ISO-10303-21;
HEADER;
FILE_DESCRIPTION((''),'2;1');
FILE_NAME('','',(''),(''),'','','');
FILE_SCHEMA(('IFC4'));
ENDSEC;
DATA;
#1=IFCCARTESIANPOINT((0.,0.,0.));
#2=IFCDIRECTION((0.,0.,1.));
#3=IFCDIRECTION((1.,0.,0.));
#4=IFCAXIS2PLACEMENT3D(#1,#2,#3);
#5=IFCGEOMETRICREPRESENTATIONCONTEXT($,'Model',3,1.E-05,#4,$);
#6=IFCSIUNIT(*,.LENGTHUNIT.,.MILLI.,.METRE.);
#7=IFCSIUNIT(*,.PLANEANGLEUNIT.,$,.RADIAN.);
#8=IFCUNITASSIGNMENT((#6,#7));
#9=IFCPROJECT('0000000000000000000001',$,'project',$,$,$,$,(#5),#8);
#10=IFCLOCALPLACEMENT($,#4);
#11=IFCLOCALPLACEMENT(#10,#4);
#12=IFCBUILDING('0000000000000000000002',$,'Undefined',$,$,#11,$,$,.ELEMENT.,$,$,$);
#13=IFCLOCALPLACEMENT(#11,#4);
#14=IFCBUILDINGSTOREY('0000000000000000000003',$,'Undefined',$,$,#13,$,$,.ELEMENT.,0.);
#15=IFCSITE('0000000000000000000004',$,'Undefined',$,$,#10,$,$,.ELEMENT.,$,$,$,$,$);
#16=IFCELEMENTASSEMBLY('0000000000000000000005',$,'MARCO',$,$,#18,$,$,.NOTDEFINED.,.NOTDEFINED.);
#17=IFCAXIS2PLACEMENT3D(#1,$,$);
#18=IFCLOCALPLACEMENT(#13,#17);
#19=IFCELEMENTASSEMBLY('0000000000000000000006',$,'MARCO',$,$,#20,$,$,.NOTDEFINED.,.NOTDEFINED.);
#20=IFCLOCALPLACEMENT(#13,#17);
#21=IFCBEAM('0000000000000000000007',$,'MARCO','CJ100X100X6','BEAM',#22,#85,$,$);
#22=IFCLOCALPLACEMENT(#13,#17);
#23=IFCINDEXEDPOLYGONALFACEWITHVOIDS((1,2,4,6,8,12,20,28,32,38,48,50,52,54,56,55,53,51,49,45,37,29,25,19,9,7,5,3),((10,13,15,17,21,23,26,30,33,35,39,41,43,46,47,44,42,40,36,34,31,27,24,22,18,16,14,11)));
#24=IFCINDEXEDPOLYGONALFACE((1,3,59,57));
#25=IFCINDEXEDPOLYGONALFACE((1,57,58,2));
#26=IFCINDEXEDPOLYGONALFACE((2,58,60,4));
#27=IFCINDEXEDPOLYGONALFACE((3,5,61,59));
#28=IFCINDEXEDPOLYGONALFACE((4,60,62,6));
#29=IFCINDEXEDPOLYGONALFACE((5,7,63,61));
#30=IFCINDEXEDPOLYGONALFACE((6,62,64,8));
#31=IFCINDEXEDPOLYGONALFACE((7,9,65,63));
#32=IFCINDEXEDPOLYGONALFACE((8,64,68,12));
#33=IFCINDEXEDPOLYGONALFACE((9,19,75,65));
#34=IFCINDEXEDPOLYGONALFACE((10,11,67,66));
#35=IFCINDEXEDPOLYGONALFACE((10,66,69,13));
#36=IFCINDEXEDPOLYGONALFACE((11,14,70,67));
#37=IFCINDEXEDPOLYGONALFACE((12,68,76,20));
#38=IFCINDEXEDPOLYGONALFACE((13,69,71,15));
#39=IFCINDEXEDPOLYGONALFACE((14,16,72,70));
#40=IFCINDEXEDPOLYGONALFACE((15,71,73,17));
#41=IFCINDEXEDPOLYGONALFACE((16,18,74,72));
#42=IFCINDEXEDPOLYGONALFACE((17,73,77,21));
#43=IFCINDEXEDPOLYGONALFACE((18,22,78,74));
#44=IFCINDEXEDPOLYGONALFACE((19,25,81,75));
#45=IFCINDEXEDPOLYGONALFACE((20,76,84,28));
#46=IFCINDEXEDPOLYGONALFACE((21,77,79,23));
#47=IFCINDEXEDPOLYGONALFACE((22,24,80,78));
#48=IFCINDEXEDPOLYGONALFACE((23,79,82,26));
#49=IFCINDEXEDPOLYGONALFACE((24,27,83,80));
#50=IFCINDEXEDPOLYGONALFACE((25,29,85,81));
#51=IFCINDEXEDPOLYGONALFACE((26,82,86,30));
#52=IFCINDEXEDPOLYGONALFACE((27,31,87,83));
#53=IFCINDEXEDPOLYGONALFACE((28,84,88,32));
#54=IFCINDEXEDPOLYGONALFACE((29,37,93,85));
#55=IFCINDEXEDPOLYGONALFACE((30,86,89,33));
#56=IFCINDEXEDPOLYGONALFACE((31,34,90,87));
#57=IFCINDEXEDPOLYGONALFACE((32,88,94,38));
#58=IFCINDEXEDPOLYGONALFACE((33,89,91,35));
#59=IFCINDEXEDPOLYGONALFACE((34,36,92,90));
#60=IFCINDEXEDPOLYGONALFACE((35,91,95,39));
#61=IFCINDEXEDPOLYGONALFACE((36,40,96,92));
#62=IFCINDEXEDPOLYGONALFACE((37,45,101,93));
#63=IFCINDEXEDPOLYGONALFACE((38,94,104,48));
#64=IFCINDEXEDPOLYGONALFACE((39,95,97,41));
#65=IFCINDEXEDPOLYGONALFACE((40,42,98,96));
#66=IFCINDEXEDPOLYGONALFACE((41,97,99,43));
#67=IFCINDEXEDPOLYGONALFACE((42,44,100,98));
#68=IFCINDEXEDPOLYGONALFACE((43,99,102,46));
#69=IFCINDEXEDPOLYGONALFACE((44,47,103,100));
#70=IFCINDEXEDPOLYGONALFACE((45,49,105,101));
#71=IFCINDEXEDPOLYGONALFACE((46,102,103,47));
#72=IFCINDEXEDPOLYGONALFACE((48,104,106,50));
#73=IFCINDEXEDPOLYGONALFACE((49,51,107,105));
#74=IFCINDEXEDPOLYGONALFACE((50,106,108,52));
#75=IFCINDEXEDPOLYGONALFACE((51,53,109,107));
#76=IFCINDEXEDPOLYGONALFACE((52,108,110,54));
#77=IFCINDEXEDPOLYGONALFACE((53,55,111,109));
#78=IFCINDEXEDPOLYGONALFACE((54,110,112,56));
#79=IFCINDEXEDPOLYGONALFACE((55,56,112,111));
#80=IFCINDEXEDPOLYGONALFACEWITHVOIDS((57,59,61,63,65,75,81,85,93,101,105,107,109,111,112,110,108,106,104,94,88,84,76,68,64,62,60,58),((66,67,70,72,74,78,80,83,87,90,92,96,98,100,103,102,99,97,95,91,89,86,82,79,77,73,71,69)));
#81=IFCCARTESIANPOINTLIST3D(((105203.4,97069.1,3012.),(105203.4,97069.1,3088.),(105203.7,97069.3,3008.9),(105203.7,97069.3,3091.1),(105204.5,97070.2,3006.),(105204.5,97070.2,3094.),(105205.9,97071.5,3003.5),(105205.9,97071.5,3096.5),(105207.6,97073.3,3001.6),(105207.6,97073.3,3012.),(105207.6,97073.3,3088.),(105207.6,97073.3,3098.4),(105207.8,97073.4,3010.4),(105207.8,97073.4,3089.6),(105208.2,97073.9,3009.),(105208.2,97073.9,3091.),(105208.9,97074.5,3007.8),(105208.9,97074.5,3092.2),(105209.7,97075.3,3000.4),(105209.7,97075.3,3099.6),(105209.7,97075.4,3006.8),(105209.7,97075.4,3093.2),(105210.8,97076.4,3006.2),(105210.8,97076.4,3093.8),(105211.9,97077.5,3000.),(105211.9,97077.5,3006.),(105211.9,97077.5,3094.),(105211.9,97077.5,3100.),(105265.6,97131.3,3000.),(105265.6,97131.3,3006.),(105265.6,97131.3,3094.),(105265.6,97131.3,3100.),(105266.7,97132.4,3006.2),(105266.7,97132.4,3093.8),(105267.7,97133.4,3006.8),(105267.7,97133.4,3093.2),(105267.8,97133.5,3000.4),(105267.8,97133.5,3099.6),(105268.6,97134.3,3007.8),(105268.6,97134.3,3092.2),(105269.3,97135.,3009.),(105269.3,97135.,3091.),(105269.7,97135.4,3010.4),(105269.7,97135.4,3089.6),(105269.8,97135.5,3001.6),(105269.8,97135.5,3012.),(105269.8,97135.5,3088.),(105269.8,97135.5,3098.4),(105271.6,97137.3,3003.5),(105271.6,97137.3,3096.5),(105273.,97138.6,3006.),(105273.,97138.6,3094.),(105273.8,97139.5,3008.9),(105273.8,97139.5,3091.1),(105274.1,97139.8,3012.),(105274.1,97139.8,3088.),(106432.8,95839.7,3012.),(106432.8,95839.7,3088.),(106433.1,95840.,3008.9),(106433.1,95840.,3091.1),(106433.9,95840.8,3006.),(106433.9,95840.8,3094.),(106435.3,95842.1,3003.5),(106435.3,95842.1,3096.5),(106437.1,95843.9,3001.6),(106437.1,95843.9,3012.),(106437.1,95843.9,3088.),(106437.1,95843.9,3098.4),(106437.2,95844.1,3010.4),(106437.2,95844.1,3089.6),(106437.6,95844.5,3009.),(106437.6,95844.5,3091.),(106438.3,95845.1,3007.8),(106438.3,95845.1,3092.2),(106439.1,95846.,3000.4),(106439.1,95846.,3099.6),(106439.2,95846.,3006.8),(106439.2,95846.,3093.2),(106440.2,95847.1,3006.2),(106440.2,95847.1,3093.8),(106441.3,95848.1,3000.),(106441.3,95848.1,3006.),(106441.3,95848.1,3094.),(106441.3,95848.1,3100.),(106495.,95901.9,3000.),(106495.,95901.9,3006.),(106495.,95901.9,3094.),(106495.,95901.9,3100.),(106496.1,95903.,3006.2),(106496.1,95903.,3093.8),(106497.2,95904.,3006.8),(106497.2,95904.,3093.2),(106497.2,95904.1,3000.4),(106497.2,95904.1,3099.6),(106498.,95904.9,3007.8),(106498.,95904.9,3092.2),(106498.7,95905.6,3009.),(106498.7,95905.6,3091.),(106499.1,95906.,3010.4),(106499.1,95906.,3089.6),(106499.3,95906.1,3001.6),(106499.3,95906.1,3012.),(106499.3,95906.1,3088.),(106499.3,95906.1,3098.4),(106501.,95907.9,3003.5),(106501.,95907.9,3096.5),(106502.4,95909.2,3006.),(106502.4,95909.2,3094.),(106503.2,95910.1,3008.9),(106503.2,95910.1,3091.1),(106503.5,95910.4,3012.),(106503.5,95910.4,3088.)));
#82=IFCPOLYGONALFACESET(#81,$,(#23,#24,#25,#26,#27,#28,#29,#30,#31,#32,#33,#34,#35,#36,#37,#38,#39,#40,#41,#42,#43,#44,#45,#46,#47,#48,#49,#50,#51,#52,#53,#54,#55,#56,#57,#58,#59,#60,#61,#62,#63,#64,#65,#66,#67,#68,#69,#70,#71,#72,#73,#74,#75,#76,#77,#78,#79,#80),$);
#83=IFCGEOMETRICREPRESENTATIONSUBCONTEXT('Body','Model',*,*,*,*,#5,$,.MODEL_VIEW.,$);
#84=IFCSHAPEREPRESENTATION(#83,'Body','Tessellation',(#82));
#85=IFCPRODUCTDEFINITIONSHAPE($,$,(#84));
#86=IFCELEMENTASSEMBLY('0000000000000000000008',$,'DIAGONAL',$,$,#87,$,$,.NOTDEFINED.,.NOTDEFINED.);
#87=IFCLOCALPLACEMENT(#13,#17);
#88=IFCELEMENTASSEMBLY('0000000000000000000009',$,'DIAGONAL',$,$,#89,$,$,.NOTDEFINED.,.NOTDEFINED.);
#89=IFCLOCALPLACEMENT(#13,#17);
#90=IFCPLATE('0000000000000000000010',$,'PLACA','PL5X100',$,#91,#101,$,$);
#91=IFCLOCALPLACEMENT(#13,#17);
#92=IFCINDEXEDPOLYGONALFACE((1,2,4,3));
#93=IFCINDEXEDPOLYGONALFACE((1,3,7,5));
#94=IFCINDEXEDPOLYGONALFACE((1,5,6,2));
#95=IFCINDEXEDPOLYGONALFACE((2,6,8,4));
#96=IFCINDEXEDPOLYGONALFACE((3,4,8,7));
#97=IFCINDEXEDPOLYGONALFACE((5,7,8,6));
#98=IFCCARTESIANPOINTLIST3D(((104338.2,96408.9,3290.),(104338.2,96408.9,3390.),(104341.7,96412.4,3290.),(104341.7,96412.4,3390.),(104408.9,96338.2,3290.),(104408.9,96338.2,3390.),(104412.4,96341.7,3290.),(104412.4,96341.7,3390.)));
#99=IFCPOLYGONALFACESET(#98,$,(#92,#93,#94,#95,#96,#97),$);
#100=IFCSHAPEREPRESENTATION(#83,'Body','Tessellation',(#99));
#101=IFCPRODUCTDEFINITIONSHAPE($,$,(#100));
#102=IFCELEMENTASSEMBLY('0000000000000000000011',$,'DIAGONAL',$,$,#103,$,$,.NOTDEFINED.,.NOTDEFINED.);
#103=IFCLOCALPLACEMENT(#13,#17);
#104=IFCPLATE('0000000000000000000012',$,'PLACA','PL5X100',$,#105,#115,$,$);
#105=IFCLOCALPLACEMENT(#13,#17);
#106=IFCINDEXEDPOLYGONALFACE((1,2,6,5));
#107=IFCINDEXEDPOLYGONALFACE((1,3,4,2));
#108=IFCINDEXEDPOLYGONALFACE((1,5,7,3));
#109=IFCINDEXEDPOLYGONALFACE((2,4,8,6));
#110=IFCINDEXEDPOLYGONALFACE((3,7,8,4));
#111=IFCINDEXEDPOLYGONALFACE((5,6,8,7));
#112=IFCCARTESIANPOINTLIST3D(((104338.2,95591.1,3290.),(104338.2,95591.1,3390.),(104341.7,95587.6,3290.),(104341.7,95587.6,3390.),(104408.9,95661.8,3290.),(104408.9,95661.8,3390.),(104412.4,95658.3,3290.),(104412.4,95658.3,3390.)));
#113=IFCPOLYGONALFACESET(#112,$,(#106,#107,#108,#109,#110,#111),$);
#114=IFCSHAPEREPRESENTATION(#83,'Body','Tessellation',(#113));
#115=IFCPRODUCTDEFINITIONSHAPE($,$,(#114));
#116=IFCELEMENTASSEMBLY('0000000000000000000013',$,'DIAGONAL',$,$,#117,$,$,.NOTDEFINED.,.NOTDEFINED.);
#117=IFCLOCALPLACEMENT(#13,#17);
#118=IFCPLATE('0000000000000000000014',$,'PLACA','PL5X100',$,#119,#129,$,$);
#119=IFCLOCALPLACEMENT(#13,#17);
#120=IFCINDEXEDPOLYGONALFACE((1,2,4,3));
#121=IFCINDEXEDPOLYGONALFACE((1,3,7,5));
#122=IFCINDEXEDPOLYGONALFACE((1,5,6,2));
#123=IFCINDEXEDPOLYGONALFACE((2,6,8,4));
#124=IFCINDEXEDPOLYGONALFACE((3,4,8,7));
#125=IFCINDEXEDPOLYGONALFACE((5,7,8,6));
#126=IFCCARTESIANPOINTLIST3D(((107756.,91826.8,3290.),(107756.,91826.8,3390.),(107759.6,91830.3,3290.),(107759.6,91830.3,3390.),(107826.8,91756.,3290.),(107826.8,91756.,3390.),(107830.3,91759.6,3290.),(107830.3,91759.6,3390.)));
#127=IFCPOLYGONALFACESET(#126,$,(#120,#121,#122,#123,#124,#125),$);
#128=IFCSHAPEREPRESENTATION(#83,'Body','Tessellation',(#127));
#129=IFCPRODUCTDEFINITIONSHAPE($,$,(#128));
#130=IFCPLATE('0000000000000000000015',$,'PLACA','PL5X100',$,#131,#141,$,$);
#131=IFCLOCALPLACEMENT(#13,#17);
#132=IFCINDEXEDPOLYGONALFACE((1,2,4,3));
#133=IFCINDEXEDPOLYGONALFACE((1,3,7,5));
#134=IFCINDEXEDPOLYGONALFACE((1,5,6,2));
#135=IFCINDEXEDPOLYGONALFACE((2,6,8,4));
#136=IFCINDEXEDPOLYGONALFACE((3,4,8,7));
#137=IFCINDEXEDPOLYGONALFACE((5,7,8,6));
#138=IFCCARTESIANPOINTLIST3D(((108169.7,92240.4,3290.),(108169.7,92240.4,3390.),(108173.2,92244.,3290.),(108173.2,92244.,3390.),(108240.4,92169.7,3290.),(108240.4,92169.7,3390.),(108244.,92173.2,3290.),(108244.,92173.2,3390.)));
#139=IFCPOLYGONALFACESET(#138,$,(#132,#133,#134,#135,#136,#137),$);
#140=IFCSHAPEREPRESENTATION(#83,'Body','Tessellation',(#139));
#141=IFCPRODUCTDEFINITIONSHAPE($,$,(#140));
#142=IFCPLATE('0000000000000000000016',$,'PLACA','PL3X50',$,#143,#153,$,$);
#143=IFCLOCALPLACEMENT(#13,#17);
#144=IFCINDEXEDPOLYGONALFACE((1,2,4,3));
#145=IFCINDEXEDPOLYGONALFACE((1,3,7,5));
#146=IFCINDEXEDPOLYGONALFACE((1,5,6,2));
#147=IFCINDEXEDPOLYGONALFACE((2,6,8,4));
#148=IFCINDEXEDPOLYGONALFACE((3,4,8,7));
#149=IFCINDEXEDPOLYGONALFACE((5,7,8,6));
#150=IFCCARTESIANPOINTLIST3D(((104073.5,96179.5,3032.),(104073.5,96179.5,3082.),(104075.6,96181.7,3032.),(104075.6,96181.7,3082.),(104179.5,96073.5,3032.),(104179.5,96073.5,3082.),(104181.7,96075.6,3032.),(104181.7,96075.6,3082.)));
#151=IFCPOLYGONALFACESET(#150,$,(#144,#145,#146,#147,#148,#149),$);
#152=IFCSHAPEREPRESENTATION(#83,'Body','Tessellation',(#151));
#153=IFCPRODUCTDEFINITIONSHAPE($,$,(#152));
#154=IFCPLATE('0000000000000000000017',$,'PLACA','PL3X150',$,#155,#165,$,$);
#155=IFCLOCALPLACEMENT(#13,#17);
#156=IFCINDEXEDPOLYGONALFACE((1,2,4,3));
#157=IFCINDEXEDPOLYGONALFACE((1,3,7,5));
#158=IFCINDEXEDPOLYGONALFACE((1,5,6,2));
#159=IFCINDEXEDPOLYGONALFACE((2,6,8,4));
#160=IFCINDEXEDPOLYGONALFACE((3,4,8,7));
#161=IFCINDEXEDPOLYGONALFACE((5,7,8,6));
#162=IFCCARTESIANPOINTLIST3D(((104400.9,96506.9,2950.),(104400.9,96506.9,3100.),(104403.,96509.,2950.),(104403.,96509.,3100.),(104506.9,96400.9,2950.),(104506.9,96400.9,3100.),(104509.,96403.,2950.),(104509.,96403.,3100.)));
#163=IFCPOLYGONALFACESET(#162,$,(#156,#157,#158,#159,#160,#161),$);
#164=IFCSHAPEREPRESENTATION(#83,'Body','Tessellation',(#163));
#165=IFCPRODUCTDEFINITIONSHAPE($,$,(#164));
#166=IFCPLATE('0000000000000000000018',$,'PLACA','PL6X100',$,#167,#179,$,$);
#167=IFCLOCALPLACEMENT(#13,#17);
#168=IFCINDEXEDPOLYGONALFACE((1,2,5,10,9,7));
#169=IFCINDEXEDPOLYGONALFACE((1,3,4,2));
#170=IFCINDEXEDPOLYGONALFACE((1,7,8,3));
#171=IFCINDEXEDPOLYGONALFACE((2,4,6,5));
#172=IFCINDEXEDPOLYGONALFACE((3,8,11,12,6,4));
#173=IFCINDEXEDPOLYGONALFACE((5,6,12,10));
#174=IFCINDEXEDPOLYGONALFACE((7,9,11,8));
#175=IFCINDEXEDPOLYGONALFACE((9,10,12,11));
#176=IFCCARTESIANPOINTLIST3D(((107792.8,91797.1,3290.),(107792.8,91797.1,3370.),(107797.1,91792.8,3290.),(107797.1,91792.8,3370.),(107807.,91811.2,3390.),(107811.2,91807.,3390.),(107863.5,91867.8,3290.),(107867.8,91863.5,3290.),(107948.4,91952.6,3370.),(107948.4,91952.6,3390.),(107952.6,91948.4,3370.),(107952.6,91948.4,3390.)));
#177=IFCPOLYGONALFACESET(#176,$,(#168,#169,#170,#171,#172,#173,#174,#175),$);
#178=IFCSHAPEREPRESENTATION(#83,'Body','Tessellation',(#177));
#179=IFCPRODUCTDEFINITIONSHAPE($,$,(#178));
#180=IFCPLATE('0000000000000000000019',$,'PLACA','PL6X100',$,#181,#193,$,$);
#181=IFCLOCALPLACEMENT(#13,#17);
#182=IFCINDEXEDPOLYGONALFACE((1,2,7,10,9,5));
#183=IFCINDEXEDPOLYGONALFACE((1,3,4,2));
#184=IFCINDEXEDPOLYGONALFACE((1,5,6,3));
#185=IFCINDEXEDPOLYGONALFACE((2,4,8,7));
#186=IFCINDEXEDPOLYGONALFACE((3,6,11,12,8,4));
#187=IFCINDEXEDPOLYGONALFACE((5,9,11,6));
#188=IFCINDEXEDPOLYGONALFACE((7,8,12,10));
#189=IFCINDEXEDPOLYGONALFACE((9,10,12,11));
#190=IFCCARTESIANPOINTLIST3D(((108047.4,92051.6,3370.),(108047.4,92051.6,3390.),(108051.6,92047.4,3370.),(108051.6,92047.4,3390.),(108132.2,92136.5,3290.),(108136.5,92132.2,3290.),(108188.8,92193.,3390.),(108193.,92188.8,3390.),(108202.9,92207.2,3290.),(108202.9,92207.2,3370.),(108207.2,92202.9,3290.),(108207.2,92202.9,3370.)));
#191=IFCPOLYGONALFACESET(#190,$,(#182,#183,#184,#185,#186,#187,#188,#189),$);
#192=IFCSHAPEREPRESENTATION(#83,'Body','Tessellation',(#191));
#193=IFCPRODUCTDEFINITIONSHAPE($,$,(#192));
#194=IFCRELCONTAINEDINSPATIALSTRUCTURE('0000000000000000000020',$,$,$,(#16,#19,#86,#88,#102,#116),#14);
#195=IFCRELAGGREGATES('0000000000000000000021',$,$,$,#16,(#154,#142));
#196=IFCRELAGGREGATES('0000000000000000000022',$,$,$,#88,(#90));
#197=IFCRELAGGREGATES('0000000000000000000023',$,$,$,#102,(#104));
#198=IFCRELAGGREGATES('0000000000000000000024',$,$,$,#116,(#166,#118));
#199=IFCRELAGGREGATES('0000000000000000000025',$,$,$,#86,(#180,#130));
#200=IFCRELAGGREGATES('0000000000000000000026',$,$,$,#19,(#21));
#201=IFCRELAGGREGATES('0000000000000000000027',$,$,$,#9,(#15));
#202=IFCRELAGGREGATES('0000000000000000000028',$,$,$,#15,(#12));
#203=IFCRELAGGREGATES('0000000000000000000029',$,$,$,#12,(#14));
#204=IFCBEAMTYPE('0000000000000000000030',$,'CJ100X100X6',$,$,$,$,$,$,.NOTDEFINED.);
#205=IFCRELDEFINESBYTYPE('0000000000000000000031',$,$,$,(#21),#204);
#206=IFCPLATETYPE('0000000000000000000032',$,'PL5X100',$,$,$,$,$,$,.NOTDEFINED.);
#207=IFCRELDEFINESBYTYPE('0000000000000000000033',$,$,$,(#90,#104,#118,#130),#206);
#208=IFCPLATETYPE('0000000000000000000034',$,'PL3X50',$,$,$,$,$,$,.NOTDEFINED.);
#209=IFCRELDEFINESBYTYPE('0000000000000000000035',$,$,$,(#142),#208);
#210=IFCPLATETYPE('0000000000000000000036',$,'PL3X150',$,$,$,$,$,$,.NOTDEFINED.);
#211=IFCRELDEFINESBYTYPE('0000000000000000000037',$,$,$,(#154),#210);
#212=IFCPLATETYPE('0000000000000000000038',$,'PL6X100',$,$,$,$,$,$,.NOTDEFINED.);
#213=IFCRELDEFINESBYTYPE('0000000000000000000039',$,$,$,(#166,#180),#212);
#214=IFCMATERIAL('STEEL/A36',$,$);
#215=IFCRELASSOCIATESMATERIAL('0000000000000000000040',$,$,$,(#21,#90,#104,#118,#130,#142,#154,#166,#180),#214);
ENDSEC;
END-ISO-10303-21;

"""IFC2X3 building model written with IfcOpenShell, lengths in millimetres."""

from ifc_helpers import new_model, si_unit, frame, origin_with_axes, origin_2d_with_axis, place, context, subcontext, project, spatial, polyline, hollow_rectangle, outline, extrude, material, type_object, element, aggregate, save


model = new_model("IFC2X3")

# Units and contexts
model_context = context("Model", 3, precision=1e-05, world=origin_with_axes())
body_context = subcontext(model_context, "Body", "Model", "MODEL_VIEW")
ifc_project = project(units=[si_unit("LENGTHUNIT", "METRE", prefix="MILLI"), si_unit("PLANEANGLEUNIT", "RADIAN")], contexts=[model_context])

# Site, building, storey
site_placement = place(None, origin_with_axes())
site = spatial("IfcSite", under=ifc_project, at=site_placement, Name="Undefined", CompositionType="ELEMENT")
building_placement = place(site_placement, origin_with_axes())
building = spatial("IfcBuilding", under=site, at=building_placement, Name="Undefined", CompositionType="ELEMENT")
storey_placement = place(building_placement, origin_with_axes())
storey = spatial("IfcBuildingStorey", under=building, at=storey_placement, Name="Undefined", CompositionType="ELEMENT", Elevation=0.0)

# Shared definitions
ifc_material_1 = material(Name="STEEL/A36")

# Element assembly
assembly_1_placement = place(storey_placement, origin_with_axes())
assembly_1 = element("IfcElementAssembly", 1, at=assembly_1_placement, inside=storey, Name="MARCO", AssemblyPlace="NOTDEFINED", PredefinedType="NOTDEFINED")

# Element assemblies, beam
assembly_2_placement = place(storey_placement, origin_with_axes())
assembly_2 = element("IfcElementAssembly", 2, at=assembly_2_placement, inside=storey, Name="MARCO", AssemblyPlace="NOTDEFINED", PredefinedType="NOTDEFINED")
beam_type_1 = type_object("IfcBeamType", Name="CJ100X100X6", PredefinedType="NOTDEFINED")
beam_1_placement = place(assembly_2_placement, frame((105238.7, 97104.4, 3050.0), z_axis=(0.0, 0.0, -1.0), x_axis=(0.70712, -0.707094, 0.0)))
beam_1 = element("IfcBeam", 3, at=beam_1_placement, type_object=beam_type_1, material=ifc_material_1, Name="MARCO", Description="CJ100X100X6", ObjectType="BEAM", context=body_context, shape_type="SweptSolid", body=[
    extrude(hollow_rectangle(XDim=100.0, YDim=100.0, WallThickness=6.0, InnerFilletRadius=6.0, OuterFilletRadius=12.0, at=origin_2d_with_axis()), frame((1738.6, 0.0, 0.0), z_axis=(-1.0, 0.0, 0.0), x_axis=(0.0, -1.0, 0.0)), (0.0, 0.0, 1.0), 1738.7),
])
assembly_3_placement = place(storey_placement, origin_with_axes())
assembly_3 = element("IfcElementAssembly", 4, at=assembly_3_placement, inside=storey, Name="DIAGONAL", AssemblyPlace="NOTDEFINED", PredefinedType="NOTDEFINED")

# Element assemblies, plates
assembly_4_placement = place(storey_placement, origin_with_axes())
assembly_4 = element("IfcElementAssembly", 5, at=assembly_4_placement, inside=storey, Name="DIAGONAL", AssemblyPlace="NOTDEFINED", PredefinedType="NOTDEFINED")
plate_type_1 = type_object("IfcPlateType", Name="PL5X100", PredefinedType="NOTDEFINED")
plate_1_placement = place(assembly_4_placement, frame((104410.6, 96339.9, 3390.0), z_axis=(0.707107, 0.707107, 0.0), x_axis=(0.0, 0.0, -1.0)))
plate_1 = element("IfcPlate", 6, at=plate_1_placement, type_object=plate_type_1, material=ifc_material_1, Name="PLACA", Description="PL5X100", context=body_context, shape_type="SweptSolid", body=[
    extrude(outline(polyline([(0.0, 0.0), (100.0, 0.0), (100.0, 100.0), (0.0, 100.0), (0.0, 0.0)])), frame((0.0, 0.0, -2.5), z_axis=(0.0, 0.0, 1.0), x_axis=(1.0, 0.0, 0.0)), (0.0, 0.0, 1.0), 5.0),
])
assembly_5_placement = place(storey_placement, origin_with_axes())
assembly_5 = element("IfcElementAssembly", 7, at=assembly_5_placement, inside=storey, Name="DIAGONAL", AssemblyPlace="NOTDEFINED", PredefinedType="NOTDEFINED")
plate_2_placement = place(assembly_5_placement, frame((104339.9, 95589.4, 3390.0), z_axis=(0.707107, -0.707107, 0.0), x_axis=(0.0, 0.0, -1.0)))
plate_2 = element("IfcPlate", 8, at=plate_2_placement, type_object=plate_type_1, material=ifc_material_1, Name="PLACA", Description="PL5X100", context=body_context, shape_type="SweptSolid", body=[
    extrude(outline(polyline([(0.0, 0.0), (100.0, 0.0), (100.0, 100.0), (0.0, 100.0), (0.0, 0.0)])), frame((0.0, 0.0, -2.5), z_axis=(0.0, 0.0, 1.0), x_axis=(1.0, 0.0, 0.0)), (0.0, 0.0, 1.0), 5.0),
])
assembly_6_placement = place(storey_placement, origin_with_axes())
assembly_6 = element("IfcElementAssembly", 9, at=assembly_6_placement, inside=storey, Name="DIAGONAL", AssemblyPlace="NOTDEFINED", PredefinedType="NOTDEFINED")
plate_3_placement = place(assembly_6_placement, frame((107793.2, 91793.2, 3390.0), z_axis=(-0.707107, -0.707107, 0.0), x_axis=(0.0, 0.0, -1.0)))
plate_3 = element("IfcPlate", 10, at=plate_3_placement, type_object=plate_type_1, material=ifc_material_1, Name="PLACA", Description="PL5X100", context=body_context, shape_type="SweptSolid", body=[
    extrude(outline(polyline([(0.0, -50.0), (0.0, 50.0), (100.0, 50.0), (100.0, -50.0), (0.0, -50.0)])), frame((0.0, 0.0, -2.5), z_axis=(0.0, 0.0, 1.0), x_axis=(1.0, 0.0, 0.0)), (0.0, 0.0, 1.0), 5.0),
])

# Plates
plate_4_placement = place(assembly_3_placement, frame((108206.8, 92206.8, 3390.0), z_axis=(0.707107, 0.707107, 0.0), x_axis=(0.0, 0.0, -1.0)))
plate_4 = element("IfcPlate", 11, at=plate_4_placement, type_object=plate_type_1, material=ifc_material_1, Name="PLACA", Description="PL5X100", context=body_context, shape_type="SweptSolid", body=[
    extrude(outline(polyline([(0.0, -50.0), (0.0, 50.0), (100.0, 50.0), (100.0, -50.0), (0.0, -50.0)])), frame((0.0, 0.0, -2.5), z_axis=(0.0, 0.0, 1.0), x_axis=(1.0, 0.0, 0.0)), (0.0, 0.0, 1.0), 5.0),
])
plate_type_2 = type_object("IfcPlateType", Name="PL3X50", PredefinedType="NOTDEFINED")
plate_5_placement = place(assembly_1_placement, frame((104180.6, 96074.5, 3082.0), z_axis=(0.707107, 0.707107, 0.0), x_axis=(0.0, 0.0, -1.0)))
plate_5 = element("IfcPlate", 12, at=plate_5_placement, type_object=plate_type_2, material=ifc_material_1, Name="PLACA", Description="PL3X50", context=body_context, shape_type="SweptSolid", body=[
    extrude(outline(polyline([(0.0, 0.0), (50.0, 0.0), (50.0, 150.0), (0.0, 150.0), (0.0, 0.0)])), frame((0.0, 0.0, -1.5), z_axis=(0.0, 0.0, 1.0), x_axis=(1.0, 0.0, 0.0)), (0.0, 0.0, 1.0), 3.0),
])
plate_type_3 = type_object("IfcPlateType", Name="PL3X150", PredefinedType="NOTDEFINED")
plate_6_placement = place(assembly_1_placement, frame((104401.9, 96508.0, 3100.0), z_axis=(0.707107, 0.707107, 0.0), x_axis=(0.707107, -0.707107, 0.0)))
plate_6 = element("IfcPlate", 13, at=plate_6_placement, type_object=plate_type_3, material=ifc_material_1, Name="PLACA", Description="PL3X150", context=body_context, shape_type="SweptSolid", body=[
    extrude(outline(polyline([(0.0, 0.0), (150.0, 0.0), (150.0, 150.0), (0.0, 150.0), (0.0, 0.0)])), frame((0.0, 0.0, -1.5), z_axis=(0.0, 0.0, 1.0), x_axis=(1.0, 0.0, 0.0)), (0.0, 0.0, 1.0), 3.0),
])
aggregate(assembly_1, [plate_6, plate_5])
plate_type_4 = type_object("IfcPlateType", Name="PL6X100", PredefinedType="NOTDEFINED")
plate_7_placement = place(assembly_6_placement, frame((107950.5, 91950.5, 3290.0), z_axis=(-0.707107, 0.707107, 0.0), x_axis=(-0.707107, -0.707107, 0.0)))
plate_7 = element("IfcPlate", 14, at=plate_7_placement, type_object=plate_type_4, material=ifc_material_1, Name="PLACA", Description="PL6X100", context=body_context, shape_type="SweptSolid", body=[
    extrude(outline(polyline([(0.0, 80.0), (120.0, 0.0), (220.0, 0.0), (220.0, 80.0), (200.0, 100.0), (0.0, 100.0), (0.0, 80.0)])), frame((0.0, 0.0, -3.0), z_axis=(0.0, 0.0, 1.0), x_axis=(1.0, 0.0, 0.0)), (0.0, 0.0, 1.0), 6.0),
])
plate_8_placement = place(assembly_3_placement, frame((108049.5, 92049.5, 3290.0), z_axis=(0.707107, -0.707107, 0.0), x_axis=(0.707107, 0.707107, 0.0)))
plate_8 = element("IfcPlate", 15, at=plate_8_placement, type_object=plate_type_4, material=ifc_material_1, Name="PLACA", Description="PL6X100", context=body_context, shape_type="SweptSolid", body=[
    extrude(outline(polyline([(0.0, 80.0), (120.0, 0.0), (220.0, 0.0), (220.0, 80.0), (200.0, 100.0), (0.0, 100.0), (0.0, 80.0)])), frame((0.0, 0.0, -3.0), z_axis=(0.0, 0.0, 1.0), x_axis=(1.0, 0.0, 0.0)), (0.0, 0.0, 1.0), 6.0),
])
aggregate(assembly_4, [plate_1])
aggregate(assembly_5, [plate_2])
aggregate(assembly_6, [plate_7, plate_3])
aggregate(assembly_3, [plate_8, plate_4])

aggregate(assembly_2, [beam_1])

save(model, "model.ifc")
